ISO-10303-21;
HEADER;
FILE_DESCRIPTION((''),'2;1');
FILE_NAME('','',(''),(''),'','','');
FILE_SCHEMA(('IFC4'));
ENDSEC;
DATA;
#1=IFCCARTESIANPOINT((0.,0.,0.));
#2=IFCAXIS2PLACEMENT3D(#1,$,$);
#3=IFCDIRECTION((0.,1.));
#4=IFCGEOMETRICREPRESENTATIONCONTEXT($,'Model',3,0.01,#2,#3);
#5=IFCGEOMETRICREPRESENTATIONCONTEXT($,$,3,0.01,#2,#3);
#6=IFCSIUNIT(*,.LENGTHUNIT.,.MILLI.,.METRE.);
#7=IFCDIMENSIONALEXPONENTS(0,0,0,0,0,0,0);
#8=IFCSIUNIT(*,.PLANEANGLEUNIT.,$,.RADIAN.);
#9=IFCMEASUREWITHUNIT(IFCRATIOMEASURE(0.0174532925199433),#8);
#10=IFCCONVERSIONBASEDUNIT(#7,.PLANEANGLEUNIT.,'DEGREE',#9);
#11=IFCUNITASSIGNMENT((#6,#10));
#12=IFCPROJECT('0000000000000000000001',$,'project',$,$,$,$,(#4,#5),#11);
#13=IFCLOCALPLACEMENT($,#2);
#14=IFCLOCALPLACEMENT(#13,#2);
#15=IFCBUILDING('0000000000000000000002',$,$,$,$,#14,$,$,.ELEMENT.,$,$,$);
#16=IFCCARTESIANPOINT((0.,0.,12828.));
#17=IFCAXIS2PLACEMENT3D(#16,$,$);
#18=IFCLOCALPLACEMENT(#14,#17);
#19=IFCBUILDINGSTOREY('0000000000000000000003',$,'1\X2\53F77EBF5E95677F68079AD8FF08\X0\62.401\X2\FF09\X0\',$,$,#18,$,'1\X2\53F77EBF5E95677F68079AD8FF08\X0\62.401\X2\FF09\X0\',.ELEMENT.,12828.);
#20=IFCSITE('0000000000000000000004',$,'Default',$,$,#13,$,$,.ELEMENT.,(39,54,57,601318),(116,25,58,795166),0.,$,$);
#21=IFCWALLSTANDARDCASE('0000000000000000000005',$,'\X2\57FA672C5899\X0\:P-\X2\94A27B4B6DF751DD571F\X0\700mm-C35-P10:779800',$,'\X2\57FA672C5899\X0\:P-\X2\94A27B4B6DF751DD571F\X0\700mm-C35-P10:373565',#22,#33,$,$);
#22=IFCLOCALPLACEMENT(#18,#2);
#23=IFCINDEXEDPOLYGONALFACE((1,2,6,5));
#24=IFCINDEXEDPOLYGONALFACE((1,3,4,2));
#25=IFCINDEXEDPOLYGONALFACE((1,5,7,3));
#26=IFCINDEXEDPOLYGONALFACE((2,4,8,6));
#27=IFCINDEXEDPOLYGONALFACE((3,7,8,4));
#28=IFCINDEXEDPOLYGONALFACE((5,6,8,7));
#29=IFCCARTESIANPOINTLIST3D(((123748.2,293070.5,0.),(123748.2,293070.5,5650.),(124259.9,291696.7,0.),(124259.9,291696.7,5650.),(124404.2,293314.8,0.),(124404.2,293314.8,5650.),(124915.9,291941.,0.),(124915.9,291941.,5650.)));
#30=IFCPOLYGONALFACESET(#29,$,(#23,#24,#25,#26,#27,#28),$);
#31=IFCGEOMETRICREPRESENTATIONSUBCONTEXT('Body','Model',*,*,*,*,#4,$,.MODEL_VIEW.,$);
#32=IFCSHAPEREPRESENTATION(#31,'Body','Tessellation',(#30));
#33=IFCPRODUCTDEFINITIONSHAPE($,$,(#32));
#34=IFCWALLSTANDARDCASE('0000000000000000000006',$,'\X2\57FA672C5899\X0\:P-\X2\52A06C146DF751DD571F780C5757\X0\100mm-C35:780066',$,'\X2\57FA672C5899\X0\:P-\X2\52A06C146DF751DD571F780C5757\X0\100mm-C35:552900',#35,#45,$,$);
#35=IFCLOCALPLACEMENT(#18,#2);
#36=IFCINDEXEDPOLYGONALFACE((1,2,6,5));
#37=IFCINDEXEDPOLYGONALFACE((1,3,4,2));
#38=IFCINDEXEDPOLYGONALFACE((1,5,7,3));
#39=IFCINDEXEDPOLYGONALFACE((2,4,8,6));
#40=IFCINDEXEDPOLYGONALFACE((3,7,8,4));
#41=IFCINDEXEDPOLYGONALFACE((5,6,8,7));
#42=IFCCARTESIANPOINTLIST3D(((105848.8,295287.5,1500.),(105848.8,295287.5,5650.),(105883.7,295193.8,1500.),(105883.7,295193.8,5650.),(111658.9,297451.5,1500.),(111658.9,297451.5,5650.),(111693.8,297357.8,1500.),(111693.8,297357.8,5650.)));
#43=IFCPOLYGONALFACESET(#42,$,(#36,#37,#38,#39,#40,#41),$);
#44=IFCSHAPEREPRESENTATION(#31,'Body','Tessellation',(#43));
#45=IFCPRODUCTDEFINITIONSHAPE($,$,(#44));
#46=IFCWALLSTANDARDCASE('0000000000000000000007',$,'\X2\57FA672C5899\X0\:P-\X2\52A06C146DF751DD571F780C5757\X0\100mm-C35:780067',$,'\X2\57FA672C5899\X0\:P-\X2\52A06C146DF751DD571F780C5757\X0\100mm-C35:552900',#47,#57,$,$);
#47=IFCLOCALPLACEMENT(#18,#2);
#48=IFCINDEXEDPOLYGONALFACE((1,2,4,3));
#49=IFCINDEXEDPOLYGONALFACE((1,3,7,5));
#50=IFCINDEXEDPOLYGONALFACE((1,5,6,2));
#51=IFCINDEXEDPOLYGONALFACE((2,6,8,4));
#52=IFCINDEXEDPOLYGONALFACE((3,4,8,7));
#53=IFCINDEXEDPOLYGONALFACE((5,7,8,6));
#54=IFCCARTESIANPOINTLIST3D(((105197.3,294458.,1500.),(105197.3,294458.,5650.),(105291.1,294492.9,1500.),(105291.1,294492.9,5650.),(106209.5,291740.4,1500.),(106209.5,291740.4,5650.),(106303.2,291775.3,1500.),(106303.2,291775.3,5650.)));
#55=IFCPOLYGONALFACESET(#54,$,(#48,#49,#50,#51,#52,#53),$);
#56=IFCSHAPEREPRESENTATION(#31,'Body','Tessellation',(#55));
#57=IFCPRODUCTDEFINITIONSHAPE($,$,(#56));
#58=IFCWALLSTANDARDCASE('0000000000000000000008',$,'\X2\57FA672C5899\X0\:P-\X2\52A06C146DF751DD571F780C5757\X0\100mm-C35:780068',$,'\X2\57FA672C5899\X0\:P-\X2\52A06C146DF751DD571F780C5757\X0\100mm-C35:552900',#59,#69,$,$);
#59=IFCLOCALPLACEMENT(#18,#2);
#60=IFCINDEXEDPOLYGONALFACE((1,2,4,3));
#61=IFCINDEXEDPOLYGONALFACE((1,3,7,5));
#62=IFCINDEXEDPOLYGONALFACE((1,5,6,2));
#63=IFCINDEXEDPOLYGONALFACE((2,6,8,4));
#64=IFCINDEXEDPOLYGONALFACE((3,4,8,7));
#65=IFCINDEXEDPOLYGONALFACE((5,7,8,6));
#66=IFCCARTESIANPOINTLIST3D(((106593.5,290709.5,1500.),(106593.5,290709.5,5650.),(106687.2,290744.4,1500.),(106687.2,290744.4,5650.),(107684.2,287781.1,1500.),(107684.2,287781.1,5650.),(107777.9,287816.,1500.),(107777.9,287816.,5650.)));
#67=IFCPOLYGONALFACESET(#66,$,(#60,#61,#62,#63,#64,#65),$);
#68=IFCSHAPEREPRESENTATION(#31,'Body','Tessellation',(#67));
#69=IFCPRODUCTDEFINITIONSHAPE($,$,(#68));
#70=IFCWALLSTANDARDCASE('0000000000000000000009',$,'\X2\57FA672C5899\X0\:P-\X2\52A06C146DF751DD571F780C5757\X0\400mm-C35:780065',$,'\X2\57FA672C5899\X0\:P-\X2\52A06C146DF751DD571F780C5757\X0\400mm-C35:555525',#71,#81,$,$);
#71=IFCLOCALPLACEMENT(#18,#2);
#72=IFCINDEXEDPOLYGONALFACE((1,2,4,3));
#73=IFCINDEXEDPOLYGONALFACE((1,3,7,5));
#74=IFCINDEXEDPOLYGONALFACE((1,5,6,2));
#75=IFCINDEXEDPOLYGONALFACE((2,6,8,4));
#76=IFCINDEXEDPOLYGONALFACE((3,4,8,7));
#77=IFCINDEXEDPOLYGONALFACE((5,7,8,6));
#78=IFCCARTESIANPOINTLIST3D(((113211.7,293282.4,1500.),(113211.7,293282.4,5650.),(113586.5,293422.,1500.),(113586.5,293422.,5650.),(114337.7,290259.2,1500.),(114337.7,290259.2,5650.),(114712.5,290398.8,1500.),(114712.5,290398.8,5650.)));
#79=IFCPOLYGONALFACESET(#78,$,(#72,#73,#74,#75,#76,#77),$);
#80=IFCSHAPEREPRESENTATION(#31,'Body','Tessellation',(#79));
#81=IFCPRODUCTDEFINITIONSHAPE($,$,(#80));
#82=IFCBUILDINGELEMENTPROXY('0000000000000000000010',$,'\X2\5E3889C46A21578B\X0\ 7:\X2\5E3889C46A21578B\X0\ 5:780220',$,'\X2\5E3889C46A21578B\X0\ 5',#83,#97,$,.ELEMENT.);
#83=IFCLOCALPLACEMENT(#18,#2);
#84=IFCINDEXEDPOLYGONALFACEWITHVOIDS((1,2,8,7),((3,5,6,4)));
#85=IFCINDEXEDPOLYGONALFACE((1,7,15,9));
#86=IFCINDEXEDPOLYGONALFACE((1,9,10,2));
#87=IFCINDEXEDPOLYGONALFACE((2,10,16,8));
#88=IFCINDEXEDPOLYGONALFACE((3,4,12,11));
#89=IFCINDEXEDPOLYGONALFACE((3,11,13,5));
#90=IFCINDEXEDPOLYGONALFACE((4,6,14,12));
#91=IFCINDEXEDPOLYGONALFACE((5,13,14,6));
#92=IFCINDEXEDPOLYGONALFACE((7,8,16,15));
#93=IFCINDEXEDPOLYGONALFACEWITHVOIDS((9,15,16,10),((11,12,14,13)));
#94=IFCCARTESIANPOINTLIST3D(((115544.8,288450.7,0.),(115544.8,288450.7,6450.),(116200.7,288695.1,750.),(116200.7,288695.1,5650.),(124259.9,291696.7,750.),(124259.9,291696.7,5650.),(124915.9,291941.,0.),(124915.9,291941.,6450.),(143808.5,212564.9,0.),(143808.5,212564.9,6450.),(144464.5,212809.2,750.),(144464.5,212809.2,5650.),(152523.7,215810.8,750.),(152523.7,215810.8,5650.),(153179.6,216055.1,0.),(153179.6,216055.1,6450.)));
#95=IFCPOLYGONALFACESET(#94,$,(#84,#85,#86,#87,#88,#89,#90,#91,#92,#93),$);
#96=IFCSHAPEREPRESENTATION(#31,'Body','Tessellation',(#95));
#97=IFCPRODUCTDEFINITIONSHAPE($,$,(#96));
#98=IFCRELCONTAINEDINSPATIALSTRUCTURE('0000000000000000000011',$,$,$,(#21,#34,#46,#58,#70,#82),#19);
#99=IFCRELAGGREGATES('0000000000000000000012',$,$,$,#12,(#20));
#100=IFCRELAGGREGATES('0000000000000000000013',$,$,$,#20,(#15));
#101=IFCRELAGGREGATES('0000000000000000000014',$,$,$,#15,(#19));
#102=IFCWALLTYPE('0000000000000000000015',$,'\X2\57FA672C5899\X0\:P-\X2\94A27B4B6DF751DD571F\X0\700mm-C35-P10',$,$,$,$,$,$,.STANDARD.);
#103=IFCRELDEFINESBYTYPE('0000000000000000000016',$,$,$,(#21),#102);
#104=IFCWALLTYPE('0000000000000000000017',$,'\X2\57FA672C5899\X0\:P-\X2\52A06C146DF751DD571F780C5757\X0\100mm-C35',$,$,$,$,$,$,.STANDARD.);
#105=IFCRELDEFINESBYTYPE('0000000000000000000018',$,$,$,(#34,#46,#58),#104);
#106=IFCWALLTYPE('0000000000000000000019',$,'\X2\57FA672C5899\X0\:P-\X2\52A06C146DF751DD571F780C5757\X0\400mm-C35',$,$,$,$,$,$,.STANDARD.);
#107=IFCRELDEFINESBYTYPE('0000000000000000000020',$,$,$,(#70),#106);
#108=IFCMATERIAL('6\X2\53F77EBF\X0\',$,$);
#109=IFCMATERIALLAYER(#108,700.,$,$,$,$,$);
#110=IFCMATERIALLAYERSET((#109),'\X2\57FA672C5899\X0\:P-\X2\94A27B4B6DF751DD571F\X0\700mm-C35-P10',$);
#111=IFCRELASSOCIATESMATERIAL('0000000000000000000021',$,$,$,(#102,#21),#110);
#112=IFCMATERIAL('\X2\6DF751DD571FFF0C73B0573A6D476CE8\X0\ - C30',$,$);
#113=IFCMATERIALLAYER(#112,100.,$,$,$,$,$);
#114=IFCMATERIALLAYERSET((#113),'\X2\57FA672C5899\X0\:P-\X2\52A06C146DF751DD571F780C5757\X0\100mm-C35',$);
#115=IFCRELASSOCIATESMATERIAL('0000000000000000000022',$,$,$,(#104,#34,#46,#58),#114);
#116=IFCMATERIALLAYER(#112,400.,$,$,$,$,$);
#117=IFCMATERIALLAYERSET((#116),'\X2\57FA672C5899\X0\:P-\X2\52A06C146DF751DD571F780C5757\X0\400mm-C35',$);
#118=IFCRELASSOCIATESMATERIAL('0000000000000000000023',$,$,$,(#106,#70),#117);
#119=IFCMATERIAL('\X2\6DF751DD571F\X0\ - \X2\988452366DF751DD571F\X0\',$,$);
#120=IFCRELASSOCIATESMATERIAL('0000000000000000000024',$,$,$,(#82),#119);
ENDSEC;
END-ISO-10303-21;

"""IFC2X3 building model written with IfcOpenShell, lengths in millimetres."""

from ifc_helpers import new_model, entity, si_unit, converted_unit, direction, frame, frame_2d, origin, place, context, subcontext, project, spatial, polyline, rectangle, outline, extrude, clip, bounded_halfspace, source, transform, mapped, material, layer, layer_set, layer_usage, type_object, element, save


model = new_model("IFC2X3")

# Units and contexts
model_context = context("Model", 3, precision=0.01, world=origin(), true_north=direction((0.0, 1.0)))
context_of_model = context(None, 3, precision=0.01, world=origin(), true_north=direction((0.0, 1.0)))
body_context = subcontext(model_context, "Body", "Model", "MODEL_VIEW")
ifc_project = project(units=[si_unit("LENGTHUNIT", "METRE", prefix="MILLI"), converted_unit("PLANEANGLEUNIT", "DEGREE", entity("IfcRatioMeasure", 0.0174532925199433), si_unit("PLANEANGLEUNIT", "RADIAN"), dimensions=[0, 0, 0, 0, 0, 0, 0])], contexts=[model_context, context_of_model])

# Site, building, storey
site_placement = place(None, origin())
site = spatial("IfcSite", under=ifc_project, at=site_placement, Name="Default", CompositionType="ELEMENT", RefLatitude=(39, 54, 57, 601318), RefLongitude=(116, 25, 58, 795166), RefElevation=0.0)
building_placement = place(site_placement, origin())
building = spatial("IfcBuilding", under=site, at=building_placement, CompositionType="ELEMENT")
storey_placement = place(building_placement, frame((0.0, 0.0, 12828.0)))
storey = spatial("IfcBuildingStorey", under=building, at=storey_placement, Name="1号线底板标高（62.401）", LongName="1号线底板标高（62.401）", CompositionType="ELEMENT", Elevation=12828.0)

# Shared definitions
ifc_material_1 = material(Name="混凝土，现场浇注 - C30")

# Walls
ifc_material_2 = material(Name="6号线")
ifc_layer_1 = layer(ifc_material_2, 700.0)
ifc_layer_set_1 = layer_set([ifc_layer_1], Name="基本墙:P-钢筋混凝土700mm-C35-P10")
ifc_layer_usage_1 = layer_usage(ifc_layer_set_1, "AXIS2", "NEGATIVE", 350.0)
wall_type_1 = type_object("IfcWallType", Name="基本墙:P-钢筋混凝土700mm-C35-P10", PredefinedType="STANDARD", material=ifc_layer_set_1)
wall_1_placement = place(storey_placement, frame((124076.2, 293192.7, 0.0), z_axis=(0.0, 0.0, 1.0), x_axis=(0.349028, -0.937112, 0.0)))
element("IfcWallStandardCase", 1, at=wall_1_placement, inside=storey, type_object=wall_type_1, material=ifc_layer_usage_1, Name="基本墙:P-钢筋混凝土700mm-C35-P10:779800", ObjectType="基本墙:P-钢筋混凝土700mm-C35-P10:373565", context=body_context, shape_type="Clipping", body=[
    clip(extrude(rectangle(XDim=1466.0, YDim=700.0, at=frame_2d((733.0, 0.0), x_axis=(-1.0, 0.0))), origin(), (0.0, 0.0, 1.0), 5650.0), bounded_halfspace(frame((0.0, -350.0, 5650.0), z_axis=(0.0, 0.0, -1.0), x_axis=(0.0, 1.0, 0.0)), True, frame((0.0, -350.0, 5650.0)), polyline([(0.0, 0.0), (1466.0, 0.0), (1466.0, 700.0), (487.5, 700.0), (0.0, 700.0), (0.0, 0.0)]))),
])
ifc_layer_2 = layer(ifc_material_1, 100.0)
ifc_layer_set_2 = layer_set([ifc_layer_2], Name="基本墙:P-加气混凝土砌块100mm-C35")
ifc_layer_usage_2 = layer_usage(ifc_layer_set_2, "AXIS2", "NEGATIVE", 50.0)
wall_type_2 = type_object("IfcWallType", Name="基本墙:P-加气混凝土砌块100mm-C35", PredefinedType="STANDARD", material=ifc_layer_set_2)
wall_2_placement = place(storey_placement, frame((105866.2, 295240.7, 1500.0), z_axis=(0.0, 0.0, 1.0), x_axis=(0.937112, 0.349028, 0.0)))
element("IfcWallStandardCase", 2, at=wall_2_placement, inside=storey, type_object=wall_type_2, material=ifc_layer_usage_2, Name="基本墙:P-加气混凝土砌块100mm-C35:780066", ObjectType="基本墙:P-加气混凝土砌块100mm-C35:552900", context=body_context, shape_type="Clipping", body=[
    clip(extrude(rectangle(XDim=6200.0, YDim=100.0, at=frame_2d((3100.0, 0.0), x_axis=(-1.0, 0.0))), origin(), (0.0, 0.0, 1.0), 4150.0), bounded_halfspace(frame((0.0, -50.0, 4150.0), z_axis=(0.0, 0.0, -1.0), x_axis=(1.0, 0.0, 0.0)), True, frame((0.0, -50.0, 4150.0)), polyline([(0.0, 0.0), (4600.0, 0.0), (4700.0, 0.0), (6200.0, 0.0), (6200.0, 100.0), (0.0, 100.0), (0.0, 0.0)]))),
])
ifc_layer_usage_3 = layer_usage(ifc_layer_set_2, "AXIS2", "NEGATIVE", 50.0)
wall_3_placement = place(storey_placement, frame((105244.2, 294475.4, 1500.0), z_axis=(0.0, 0.0, 1.0), x_axis=(0.349028, -0.937112, 0.0)))
element("IfcWallStandardCase", 3, at=wall_3_placement, inside=storey, type_object=wall_type_2, material=ifc_layer_usage_3, Name="基本墙:P-加气混凝土砌块100mm-C35:780067", ObjectType="基本墙:P-加气混凝土砌块100mm-C35:552900", context=body_context, shape_type="Clipping", body=[
    clip(extrude(rectangle(XDim=2900.0, YDim=100.0, at=frame_2d((1450.0, 0.0), x_axis=(-1.0, 0.0))), origin(), (0.0, 0.0, 1.0), 4150.0), bounded_halfspace(frame((0.0, -50.0, 4150.0), z_axis=(0.0, 0.0, -1.0), x_axis=(0.0, 1.0, 0.0)), True, frame((0.0, -50.0, 4150.0)), polyline([(0.0, 0.0), (2900.0, 0.0), (2900.0, 100.0), (0.0, 100.0), (0.0, 0.0)]))),
])
ifc_layer_usage_4 = layer_usage(ifc_layer_set_2, "AXIS2", "NEGATIVE", 50.0)
wall_4_placement = place(storey_placement, frame((106640.3, 290727.0, 1500.0), z_axis=(0.0, 0.0, 1.0), x_axis=(0.349028, -0.937112, 0.0)))
element("IfcWallStandardCase", 4, at=wall_4_placement, inside=storey, type_object=wall_type_2, material=ifc_layer_usage_4, Name="基本墙:P-加气混凝土砌块100mm-C35:780068", ObjectType="基本墙:P-加气混凝土砌块100mm-C35:552900", context=body_context, shape_type="Clipping", body=[
    clip(extrude(rectangle(XDim=3125.0, YDim=100.0, at=frame_2d((1562.5, 0.0), x_axis=(-1.0, 0.0))), origin(), (0.0, 0.0, 1.0), 4150.0), bounded_halfspace(frame((0.0, -50.0, 4150.0), z_axis=(0.0, 0.0, -1.0), x_axis=(0.0, 1.0, 0.0)), True, frame((0.0, -50.0, 4150.0)), polyline([(0.0, 0.0), (3125.0, 0.0), (3125.0, 100.0), (0.0, 100.0), (0.0, 0.0)]))),
])
ifc_layer_3 = layer(ifc_material_1, 400.0)
ifc_layer_set_3 = layer_set([ifc_layer_3], Name="基本墙:P-加气混凝土砌块400mm-C35")
ifc_layer_usage_5 = layer_usage(ifc_layer_set_3, "AXIS2", "NEGATIVE", 200.0)
wall_type_3 = type_object("IfcWallType", Name="基本墙:P-加气混凝土砌块400mm-C35", PredefinedType="STANDARD", material=ifc_layer_set_3)
wall_5_placement = place(storey_placement, frame((113399.1, 293352.2, 1500.0), z_axis=(0.0, 0.0, 1.0), x_axis=(0.349028, -0.937112, 0.0)))
element("IfcWallStandardCase", 5, at=wall_5_placement, inside=storey, type_object=wall_type_3, material=ifc_layer_usage_5, Name="基本墙:P-加气混凝土砌块400mm-C35:780065", ObjectType="基本墙:P-加气混凝土砌块400mm-C35:555525", context=body_context, shape_type="Clipping", body=[
    clip(extrude(rectangle(XDim=3226.1, YDim=400.0, at=frame_2d((1613.1, 0.0), x_axis=(-1.0, 0.0))), origin(), (0.0, 0.0, 1.0), 4150.0), bounded_halfspace(frame((0.0, -200.0, 4150.0), z_axis=(0.0, 0.0, -1.0), x_axis=(0.0, 1.0, 0.0)), True, frame((0.0, -200.0, 4150.0)), polyline([(0.0, 0.0), (3226.1, 0.0), (3226.1, 400.0), (0.0, 400.0), (0.0, 0.0)]))),
])

# Building element proxy
ifc_material_3 = material(Name="混凝土 - 预制混凝土")
shared_shape_1 = source(origin(), body_context, "Body", "SweptSolid", [
    extrude(outline(polyline([(-3225.0, -5000.0), (3225.0, -5000.0), (3225.0, 5000.0), (-3225.0, 5000.0), (-3225.0, -5000.0)]), holes=[polyline([(-2475.0, 4300.0), (2425.0, 4300.0), (2425.0, -4300.0), (-2475.0, -4300.0), (-2475.0, 4300.0)])]), frame((32949.3, 1745.1, 3225.0), z_axis=(-0.349028, 0.937112, 0.0), x_axis=(0.0, 0.0, 1.0)), (0.0, 0.0, 1.0), 80978.4),
])
proxy_placement = place(storey_placement, frame((115544.8, 212564.9, 0.0)))
element("IfcBuildingElementProxy", 6, at=proxy_placement, inside=storey, material=ifc_material_3, Name="常规模型 7:常规模型 5:780220", ObjectType="常规模型 5", CompositionType="ELEMENT", context=body_context, shape_type="MappedRepresentation", body=[
    mapped(shared_shape_1, transform((0.0, 0.0, 0.0), scale=1.0)),
])

save(model, "model.ifc")
